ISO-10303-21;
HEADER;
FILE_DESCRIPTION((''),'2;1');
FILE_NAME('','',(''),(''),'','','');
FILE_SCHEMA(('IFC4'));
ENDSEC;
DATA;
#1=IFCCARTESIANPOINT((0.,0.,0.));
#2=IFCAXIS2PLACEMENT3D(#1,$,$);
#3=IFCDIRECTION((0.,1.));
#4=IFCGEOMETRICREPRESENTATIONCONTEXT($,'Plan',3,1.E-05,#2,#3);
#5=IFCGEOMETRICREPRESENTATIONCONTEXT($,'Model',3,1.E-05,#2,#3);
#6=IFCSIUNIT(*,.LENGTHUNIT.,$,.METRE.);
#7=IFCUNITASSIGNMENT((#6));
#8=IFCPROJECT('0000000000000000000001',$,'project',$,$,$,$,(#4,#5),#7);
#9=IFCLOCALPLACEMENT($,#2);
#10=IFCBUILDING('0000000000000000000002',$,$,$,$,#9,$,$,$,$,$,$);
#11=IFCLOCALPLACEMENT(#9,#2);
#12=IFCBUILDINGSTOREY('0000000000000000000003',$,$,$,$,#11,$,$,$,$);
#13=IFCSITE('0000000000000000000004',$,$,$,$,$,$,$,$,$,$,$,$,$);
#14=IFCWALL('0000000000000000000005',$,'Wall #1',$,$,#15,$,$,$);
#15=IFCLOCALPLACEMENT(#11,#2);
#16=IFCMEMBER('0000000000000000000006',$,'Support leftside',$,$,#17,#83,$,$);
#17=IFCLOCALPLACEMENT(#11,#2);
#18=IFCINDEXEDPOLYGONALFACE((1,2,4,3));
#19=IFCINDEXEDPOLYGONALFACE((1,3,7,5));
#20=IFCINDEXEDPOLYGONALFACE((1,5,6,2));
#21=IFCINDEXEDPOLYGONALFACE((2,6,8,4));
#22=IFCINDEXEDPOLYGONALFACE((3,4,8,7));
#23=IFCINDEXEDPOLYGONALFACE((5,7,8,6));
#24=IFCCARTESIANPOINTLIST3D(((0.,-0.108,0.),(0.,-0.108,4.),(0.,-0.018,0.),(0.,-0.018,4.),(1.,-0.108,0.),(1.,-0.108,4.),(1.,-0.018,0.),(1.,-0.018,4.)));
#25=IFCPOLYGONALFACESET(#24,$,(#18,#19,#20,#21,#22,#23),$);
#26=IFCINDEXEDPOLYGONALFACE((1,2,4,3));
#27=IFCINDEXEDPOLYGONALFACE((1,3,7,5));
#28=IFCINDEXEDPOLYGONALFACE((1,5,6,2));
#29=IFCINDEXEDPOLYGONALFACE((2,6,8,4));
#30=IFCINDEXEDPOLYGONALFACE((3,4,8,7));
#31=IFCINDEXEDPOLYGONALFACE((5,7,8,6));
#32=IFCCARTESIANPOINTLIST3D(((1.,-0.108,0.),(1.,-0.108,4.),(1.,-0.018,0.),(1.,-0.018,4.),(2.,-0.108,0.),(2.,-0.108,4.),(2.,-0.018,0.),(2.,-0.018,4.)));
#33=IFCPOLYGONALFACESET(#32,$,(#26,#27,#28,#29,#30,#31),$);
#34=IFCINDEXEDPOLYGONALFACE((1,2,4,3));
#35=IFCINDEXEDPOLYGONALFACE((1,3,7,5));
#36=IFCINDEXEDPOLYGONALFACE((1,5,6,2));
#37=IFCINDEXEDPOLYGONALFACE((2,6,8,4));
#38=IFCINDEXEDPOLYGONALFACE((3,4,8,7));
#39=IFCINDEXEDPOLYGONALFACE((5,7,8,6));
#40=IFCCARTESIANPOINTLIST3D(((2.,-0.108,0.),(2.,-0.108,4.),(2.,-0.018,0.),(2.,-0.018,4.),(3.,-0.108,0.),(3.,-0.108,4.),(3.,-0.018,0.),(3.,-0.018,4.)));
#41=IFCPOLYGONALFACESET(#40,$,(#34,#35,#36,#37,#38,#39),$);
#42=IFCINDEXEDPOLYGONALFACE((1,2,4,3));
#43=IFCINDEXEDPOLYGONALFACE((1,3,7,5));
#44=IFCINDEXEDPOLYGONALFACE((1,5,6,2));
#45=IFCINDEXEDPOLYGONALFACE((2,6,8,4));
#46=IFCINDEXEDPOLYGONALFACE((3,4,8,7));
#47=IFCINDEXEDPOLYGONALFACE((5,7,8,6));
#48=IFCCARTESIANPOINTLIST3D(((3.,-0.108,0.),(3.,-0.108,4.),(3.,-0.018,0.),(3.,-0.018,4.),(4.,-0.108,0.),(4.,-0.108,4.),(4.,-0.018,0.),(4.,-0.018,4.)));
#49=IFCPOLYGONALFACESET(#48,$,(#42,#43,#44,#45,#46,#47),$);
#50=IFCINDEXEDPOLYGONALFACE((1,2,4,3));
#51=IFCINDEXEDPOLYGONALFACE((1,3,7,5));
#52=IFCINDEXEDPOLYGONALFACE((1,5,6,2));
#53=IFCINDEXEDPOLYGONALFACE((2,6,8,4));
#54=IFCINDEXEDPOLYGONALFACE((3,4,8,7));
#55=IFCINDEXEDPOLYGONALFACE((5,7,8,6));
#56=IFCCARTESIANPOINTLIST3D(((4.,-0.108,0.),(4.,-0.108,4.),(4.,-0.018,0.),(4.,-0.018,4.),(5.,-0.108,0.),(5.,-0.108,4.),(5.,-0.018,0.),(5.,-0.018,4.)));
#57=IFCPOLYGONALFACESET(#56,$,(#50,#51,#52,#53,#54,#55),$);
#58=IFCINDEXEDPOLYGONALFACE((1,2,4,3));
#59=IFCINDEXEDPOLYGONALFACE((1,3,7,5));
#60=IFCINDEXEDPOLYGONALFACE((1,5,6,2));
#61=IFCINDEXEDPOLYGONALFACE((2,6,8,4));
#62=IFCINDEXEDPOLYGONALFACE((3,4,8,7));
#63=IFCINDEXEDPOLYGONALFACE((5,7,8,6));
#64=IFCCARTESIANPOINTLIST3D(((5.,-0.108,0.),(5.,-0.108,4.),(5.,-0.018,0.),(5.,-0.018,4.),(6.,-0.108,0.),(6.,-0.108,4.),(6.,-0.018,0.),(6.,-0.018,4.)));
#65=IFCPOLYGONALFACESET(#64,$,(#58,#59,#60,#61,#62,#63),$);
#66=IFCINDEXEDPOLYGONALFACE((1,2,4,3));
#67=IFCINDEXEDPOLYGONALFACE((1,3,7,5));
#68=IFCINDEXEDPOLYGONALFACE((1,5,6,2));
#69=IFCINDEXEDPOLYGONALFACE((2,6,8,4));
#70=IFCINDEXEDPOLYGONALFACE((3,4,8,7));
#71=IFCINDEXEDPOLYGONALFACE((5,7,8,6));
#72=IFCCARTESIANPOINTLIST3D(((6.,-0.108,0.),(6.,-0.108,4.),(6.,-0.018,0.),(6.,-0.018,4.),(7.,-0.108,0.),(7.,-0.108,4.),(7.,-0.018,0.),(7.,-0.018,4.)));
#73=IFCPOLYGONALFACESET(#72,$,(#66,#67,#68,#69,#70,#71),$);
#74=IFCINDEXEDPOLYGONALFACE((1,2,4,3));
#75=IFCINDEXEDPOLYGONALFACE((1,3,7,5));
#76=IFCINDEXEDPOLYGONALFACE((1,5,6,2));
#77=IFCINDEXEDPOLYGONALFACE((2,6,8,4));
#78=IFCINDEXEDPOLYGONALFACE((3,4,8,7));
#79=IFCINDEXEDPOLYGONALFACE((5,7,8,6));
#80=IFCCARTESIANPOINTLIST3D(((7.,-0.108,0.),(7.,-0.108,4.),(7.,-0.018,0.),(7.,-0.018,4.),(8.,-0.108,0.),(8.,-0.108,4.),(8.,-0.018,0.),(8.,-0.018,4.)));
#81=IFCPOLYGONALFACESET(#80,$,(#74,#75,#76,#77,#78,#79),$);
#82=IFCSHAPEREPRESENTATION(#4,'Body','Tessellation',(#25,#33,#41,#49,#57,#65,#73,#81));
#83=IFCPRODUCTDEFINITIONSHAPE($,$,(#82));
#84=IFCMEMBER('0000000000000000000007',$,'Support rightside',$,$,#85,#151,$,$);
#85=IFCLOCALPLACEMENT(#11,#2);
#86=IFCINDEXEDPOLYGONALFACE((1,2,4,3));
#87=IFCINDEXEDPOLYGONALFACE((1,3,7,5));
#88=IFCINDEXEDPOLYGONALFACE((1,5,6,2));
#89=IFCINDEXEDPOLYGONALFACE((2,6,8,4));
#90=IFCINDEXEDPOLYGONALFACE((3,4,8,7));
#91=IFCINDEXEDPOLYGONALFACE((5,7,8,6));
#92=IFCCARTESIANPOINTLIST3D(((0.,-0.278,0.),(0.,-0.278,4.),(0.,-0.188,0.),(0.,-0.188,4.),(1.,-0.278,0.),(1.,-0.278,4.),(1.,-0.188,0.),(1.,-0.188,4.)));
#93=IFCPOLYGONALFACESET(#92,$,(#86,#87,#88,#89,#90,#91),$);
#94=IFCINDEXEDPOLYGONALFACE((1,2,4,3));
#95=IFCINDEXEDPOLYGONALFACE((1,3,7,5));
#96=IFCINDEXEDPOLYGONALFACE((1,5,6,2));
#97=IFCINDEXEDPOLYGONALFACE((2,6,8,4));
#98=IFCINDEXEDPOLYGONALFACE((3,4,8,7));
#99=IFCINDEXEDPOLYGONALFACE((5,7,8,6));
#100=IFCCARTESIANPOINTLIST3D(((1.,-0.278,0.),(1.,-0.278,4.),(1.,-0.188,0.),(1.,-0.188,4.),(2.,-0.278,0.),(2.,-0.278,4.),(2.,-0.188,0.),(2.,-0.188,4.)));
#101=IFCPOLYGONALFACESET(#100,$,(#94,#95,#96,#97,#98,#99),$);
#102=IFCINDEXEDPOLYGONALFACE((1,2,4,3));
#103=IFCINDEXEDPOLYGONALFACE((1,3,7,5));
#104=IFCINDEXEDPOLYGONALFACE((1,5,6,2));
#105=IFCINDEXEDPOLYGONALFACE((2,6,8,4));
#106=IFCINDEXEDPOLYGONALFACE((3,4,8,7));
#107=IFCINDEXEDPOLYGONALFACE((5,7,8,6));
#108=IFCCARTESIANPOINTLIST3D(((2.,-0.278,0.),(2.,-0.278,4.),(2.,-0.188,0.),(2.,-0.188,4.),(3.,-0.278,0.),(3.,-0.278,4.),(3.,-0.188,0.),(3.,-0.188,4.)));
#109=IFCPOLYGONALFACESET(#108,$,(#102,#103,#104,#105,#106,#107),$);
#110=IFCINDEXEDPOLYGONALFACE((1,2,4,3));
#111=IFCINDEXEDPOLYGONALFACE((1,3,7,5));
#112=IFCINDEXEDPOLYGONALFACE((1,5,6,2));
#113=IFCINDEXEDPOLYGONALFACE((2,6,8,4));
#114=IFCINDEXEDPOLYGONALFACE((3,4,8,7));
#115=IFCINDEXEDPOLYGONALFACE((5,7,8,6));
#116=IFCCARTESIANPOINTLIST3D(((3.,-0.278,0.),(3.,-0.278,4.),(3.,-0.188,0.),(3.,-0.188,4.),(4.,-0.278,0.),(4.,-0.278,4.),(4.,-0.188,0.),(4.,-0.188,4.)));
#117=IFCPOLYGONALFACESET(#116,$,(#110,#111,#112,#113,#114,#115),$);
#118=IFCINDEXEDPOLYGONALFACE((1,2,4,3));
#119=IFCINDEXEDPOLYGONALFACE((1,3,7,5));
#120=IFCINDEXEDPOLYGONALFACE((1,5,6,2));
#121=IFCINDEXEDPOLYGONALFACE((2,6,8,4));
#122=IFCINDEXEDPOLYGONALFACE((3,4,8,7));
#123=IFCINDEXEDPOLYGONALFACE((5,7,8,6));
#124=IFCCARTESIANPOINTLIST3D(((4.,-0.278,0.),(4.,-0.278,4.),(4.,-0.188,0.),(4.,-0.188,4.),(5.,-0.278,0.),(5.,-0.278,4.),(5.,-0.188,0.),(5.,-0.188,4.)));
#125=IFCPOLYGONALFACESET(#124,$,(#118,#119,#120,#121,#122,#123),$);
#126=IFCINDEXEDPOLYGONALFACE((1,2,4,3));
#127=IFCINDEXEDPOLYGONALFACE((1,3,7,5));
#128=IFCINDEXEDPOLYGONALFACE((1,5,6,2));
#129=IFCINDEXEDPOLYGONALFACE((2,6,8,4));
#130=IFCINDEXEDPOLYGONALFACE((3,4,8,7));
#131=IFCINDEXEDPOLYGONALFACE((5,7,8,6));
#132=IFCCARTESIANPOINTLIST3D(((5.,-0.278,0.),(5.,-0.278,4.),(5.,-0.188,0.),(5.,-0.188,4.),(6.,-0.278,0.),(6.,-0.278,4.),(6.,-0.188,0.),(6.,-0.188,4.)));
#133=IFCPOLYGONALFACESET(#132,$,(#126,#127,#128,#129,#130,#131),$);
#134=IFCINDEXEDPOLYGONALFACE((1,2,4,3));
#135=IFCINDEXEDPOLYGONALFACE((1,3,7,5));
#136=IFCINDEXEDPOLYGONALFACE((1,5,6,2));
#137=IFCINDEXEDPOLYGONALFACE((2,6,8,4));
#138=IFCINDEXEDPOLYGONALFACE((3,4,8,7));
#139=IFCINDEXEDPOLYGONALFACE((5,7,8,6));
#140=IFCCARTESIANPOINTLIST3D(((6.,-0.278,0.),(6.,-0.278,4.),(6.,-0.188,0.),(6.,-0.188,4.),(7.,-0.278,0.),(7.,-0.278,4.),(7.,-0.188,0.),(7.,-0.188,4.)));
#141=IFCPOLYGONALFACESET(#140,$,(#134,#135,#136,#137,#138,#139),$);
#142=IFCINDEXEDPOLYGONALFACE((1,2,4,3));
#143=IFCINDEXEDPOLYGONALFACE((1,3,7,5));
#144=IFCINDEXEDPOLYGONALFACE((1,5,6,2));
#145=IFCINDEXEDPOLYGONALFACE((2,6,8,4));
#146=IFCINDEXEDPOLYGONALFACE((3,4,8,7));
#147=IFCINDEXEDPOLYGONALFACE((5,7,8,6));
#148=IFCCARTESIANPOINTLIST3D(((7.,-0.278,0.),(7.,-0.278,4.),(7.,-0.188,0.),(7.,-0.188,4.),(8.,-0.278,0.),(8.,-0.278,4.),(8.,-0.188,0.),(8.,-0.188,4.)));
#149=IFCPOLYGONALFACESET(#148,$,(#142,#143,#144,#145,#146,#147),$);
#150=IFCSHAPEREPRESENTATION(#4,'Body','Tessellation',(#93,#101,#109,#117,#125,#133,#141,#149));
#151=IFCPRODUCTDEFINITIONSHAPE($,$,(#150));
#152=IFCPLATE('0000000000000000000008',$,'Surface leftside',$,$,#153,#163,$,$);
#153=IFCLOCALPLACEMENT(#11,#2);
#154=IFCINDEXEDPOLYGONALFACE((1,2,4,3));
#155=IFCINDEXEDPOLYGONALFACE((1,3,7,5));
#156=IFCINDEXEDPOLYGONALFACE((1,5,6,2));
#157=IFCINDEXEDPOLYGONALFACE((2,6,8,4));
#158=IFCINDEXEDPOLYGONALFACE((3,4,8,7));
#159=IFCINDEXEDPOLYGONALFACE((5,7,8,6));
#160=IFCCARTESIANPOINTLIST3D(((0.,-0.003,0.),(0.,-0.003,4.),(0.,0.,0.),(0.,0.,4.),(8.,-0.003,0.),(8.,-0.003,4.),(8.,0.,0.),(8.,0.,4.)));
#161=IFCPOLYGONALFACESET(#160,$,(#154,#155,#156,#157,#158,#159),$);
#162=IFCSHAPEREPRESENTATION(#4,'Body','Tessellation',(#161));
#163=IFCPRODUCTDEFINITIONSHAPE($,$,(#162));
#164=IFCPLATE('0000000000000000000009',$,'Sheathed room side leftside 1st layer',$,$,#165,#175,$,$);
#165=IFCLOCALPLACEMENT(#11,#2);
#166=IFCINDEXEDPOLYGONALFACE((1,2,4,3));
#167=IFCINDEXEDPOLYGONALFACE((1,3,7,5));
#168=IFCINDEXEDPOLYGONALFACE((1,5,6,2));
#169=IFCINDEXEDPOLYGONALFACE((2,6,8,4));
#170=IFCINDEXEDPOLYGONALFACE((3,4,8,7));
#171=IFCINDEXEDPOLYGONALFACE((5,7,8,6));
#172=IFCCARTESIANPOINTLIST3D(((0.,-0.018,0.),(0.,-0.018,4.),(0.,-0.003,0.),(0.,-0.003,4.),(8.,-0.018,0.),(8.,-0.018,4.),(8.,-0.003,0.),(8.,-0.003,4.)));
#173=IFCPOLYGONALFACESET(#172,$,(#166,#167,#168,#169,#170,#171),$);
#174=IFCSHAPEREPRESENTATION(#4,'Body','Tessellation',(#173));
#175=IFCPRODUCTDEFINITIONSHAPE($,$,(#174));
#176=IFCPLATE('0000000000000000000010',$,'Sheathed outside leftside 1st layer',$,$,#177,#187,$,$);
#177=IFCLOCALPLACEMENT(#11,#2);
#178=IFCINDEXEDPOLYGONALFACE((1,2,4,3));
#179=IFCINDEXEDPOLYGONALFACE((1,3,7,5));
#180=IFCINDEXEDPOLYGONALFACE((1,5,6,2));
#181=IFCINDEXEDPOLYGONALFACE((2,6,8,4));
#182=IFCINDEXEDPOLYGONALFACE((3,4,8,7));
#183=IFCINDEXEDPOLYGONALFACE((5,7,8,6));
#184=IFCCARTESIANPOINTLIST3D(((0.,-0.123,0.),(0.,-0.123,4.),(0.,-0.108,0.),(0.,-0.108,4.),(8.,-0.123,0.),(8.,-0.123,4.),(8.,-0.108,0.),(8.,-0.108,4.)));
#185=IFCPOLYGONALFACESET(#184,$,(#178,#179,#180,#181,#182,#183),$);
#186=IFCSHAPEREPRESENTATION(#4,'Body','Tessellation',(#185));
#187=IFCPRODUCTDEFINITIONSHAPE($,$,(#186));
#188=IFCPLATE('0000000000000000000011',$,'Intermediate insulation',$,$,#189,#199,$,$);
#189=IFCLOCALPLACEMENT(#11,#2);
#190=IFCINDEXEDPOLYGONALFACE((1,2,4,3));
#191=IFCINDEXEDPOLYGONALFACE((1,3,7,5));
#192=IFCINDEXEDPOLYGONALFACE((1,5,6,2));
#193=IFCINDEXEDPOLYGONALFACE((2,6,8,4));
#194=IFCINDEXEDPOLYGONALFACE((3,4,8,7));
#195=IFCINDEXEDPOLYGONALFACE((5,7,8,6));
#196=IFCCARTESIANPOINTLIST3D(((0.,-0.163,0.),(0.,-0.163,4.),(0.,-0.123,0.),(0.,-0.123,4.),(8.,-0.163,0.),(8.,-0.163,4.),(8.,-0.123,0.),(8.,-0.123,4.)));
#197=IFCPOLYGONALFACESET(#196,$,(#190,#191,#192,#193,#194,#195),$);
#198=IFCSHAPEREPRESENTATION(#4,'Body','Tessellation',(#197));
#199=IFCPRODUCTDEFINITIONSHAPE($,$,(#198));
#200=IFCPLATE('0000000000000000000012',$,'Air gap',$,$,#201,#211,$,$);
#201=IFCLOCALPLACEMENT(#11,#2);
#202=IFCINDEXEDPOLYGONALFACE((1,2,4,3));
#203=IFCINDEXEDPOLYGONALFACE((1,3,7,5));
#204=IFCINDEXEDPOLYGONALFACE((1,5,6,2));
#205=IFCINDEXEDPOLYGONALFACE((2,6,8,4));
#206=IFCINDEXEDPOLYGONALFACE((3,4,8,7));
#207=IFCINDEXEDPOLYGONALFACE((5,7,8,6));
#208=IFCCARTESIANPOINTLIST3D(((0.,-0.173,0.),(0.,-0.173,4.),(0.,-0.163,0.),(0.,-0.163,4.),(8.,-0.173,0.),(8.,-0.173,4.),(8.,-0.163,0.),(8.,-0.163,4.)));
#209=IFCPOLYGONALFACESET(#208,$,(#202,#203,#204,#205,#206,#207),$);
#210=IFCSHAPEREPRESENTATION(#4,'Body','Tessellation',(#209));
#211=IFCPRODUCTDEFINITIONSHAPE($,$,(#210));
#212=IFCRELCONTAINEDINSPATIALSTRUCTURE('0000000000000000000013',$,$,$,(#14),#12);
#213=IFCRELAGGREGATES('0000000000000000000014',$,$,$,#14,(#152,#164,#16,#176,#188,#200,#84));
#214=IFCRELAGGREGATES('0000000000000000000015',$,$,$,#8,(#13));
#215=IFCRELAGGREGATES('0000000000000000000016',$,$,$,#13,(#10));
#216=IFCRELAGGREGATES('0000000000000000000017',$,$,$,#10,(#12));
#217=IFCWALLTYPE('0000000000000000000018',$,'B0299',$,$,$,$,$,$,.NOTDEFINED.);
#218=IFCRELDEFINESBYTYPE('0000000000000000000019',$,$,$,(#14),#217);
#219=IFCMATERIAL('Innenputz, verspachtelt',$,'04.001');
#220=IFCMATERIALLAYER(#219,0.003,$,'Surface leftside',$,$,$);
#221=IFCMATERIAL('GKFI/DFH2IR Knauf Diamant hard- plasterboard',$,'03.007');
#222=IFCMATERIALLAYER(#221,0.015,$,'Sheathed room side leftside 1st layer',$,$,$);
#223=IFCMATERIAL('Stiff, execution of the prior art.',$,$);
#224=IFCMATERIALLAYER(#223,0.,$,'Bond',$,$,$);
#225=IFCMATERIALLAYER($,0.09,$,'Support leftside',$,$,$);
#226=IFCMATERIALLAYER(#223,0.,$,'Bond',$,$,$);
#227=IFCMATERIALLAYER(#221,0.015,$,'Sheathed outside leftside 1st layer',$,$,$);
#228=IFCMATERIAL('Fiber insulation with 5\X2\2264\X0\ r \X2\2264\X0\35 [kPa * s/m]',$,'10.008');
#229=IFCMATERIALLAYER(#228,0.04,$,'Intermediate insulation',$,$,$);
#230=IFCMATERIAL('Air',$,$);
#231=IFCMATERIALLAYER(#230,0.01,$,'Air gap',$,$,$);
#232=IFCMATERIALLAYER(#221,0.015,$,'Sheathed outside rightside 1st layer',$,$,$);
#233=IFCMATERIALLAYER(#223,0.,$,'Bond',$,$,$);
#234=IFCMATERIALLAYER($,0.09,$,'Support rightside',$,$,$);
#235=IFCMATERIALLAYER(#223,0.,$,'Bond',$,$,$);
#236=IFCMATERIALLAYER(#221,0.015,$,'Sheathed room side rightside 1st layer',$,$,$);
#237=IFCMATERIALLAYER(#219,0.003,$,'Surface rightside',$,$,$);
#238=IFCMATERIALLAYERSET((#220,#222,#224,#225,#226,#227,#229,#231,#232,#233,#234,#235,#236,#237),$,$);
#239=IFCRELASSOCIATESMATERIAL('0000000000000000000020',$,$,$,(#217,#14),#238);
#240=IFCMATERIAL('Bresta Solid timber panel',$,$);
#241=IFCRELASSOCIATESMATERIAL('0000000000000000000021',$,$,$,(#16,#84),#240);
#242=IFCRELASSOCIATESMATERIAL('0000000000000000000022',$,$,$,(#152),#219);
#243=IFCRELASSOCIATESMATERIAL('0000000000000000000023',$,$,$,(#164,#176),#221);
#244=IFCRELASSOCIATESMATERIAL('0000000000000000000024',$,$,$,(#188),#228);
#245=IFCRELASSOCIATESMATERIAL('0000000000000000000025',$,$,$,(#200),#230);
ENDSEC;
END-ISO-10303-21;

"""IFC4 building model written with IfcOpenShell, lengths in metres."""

from ifc_helpers import new_model, si_unit, direction, frame, frame_2d, origin, origin_with_axes, place, context, project, spatial, rectangle, extrude, material, layer, layer_set, type_object, element, aggregate, save


model = new_model("IFC4")

# Units and contexts
plan_context = context("Plan", 3, precision=1e-05, world=origin(), true_north=direction((0.0, 1.0)))
model_context = context("Model", 3, precision=1e-05, world=origin(), true_north=direction((0.0, 1.0)))
ifc_project = project(units=[si_unit("LENGTHUNIT", "METRE")], contexts=[plan_context, model_context])

# Site, building, storey
site = spatial("IfcSite", under=ifc_project)
building_placement = place(None, origin())
building = spatial("IfcBuilding", under=site, at=building_placement)
storey_placement = place(building_placement, origin())
storey = spatial("IfcBuildingStorey", under=building, at=storey_placement)

# Wall, members, plates
ifc_material_1 = material(Name="Innenputz, verspachtelt", Category="04.001")
ifc_layer_1 = layer(ifc_material_1, 0.003, Name="Surface leftside")
ifc_material_2 = material(Name="GKFI/DFH2IR Knauf Diamant hard- plasterboard", Category="03.007")
ifc_layer_2 = layer(ifc_material_2, 0.015, Name="Sheathed room side leftside 1st layer")
ifc_material_3 = material(Name="Stiff, execution of the prior art.")
ifc_layer_3 = layer(ifc_material_3, 0.0, Name="Bond")
ifc_layer_4 = layer(None, 0.09, Name="Support leftside")
ifc_layer_5 = layer(ifc_material_3, 0.0, Name="Bond")
ifc_layer_6 = layer(ifc_material_2, 0.015, Name="Sheathed outside leftside 1st layer")
ifc_material_4 = material(Name="Fiber insulation with 5≤ r ≤35 [kPa * s/m]", Category="10.008")
ifc_layer_7 = layer(ifc_material_4, 0.04, Name="Intermediate insulation")
ifc_material_5 = material(Name="Air")
ifc_layer_8 = layer(ifc_material_5, 0.01, Name="Air gap")
ifc_layer_9 = layer(ifc_material_2, 0.015, Name="Sheathed outside rightside 1st layer")
ifc_layer_10 = layer(ifc_material_3, 0.0, Name="Bond")
ifc_layer_11 = layer(None, 0.09, Name="Support rightside")
ifc_layer_12 = layer(ifc_material_3, 0.0, Name="Bond")
ifc_layer_13 = layer(ifc_material_2, 0.015, Name="Sheathed room side rightside 1st layer")
ifc_layer_14 = layer(ifc_material_1, 0.003, Name="Surface rightside")
ifc_layer_set = layer_set([ifc_layer_1, ifc_layer_2, ifc_layer_3, ifc_layer_4, ifc_layer_5, ifc_layer_6, ifc_layer_7, ifc_layer_8, ifc_layer_9, ifc_layer_10, ifc_layer_11, ifc_layer_12, ifc_layer_13, ifc_layer_14])
wall_type = type_object("IfcWallType", Name="B0299", PredefinedType="NOTDEFINED", material=ifc_layer_set)
wall_placement = place(None, frame((0.0, 0.0, 0.0), z_axis=(0.0, -1.0, 0.0), x_axis=(1.0, 0.0, 0.0)))
wall = element("IfcWall", 1, at=wall_placement, inside=storey, type_object=wall_type, material=ifc_layer_set, Name="Wall #1")
ifc_material_6 = material(Name="Bresta Solid timber panel")
member_1_placement = place(wall_placement, origin())
member_1 = element("IfcMember", 2, at=member_1_placement, material=ifc_material_6, Name="Support leftside", context=plan_context, shape_type="SweptSolid", body=[
    extrude(rectangle(XDim=1.0, YDim=0.09, at=frame_2d((0.5, 0.045), x_axis=(1.0, 0.0))), frame((0.0, 4.0, 0.018), z_axis=(0.0, -1.0, 0.0), x_axis=(1.0, 0.0, 0.0)), (0.0, 0.0, 1.0), 4.0),
    extrude(rectangle(XDim=1.0, YDim=0.09, at=frame_2d((0.5, 0.045), x_axis=(1.0, 0.0))), frame((1.0, 4.0, 0.018), z_axis=(0.0, -1.0, 0.0), x_axis=(1.0, 0.0, 0.0)), (0.0, 0.0, 1.0), 4.0),
    extrude(rectangle(XDim=1.0, YDim=0.09, at=frame_2d((0.5, 0.045), x_axis=(1.0, 0.0))), frame((2.0, 4.0, 0.018), z_axis=(0.0, -1.0, 0.0), x_axis=(1.0, 0.0, 0.0)), (0.0, 0.0, 1.0), 4.0),
    extrude(rectangle(XDim=1.0, YDim=0.09, at=frame_2d((0.5, 0.045), x_axis=(1.0, 0.0))), frame((3.0, 4.0, 0.018), z_axis=(0.0, -1.0, 0.0), x_axis=(1.0, 0.0, 0.0)), (0.0, 0.0, 1.0), 4.0),
    extrude(rectangle(XDim=1.0, YDim=0.09, at=frame_2d((0.5, 0.045), x_axis=(1.0, 0.0))), frame((4.0, 4.0, 0.018), z_axis=(0.0, -1.0, 0.0), x_axis=(1.0, 0.0, 0.0)), (0.0, 0.0, 1.0), 4.0),
    extrude(rectangle(XDim=1.0, YDim=0.09, at=frame_2d((0.5, 0.045), x_axis=(1.0, 0.0))), frame((5.0, 4.0, 0.018), z_axis=(0.0, -1.0, 0.0), x_axis=(1.0, 0.0, 0.0)), (0.0, 0.0, 1.0), 4.0),
    extrude(rectangle(XDim=1.0, YDim=0.09, at=frame_2d((0.5, 0.045), x_axis=(1.0, 0.0))), frame((6.0, 4.0, 0.018), z_axis=(0.0, -1.0, 0.0), x_axis=(1.0, 0.0, 0.0)), (0.0, 0.0, 1.0), 4.0),
    extrude(rectangle(XDim=1.0, YDim=0.09, at=frame_2d((0.5, 0.045), x_axis=(1.0, 0.0))), frame((7.0, 4.0, 0.018), z_axis=(0.0, -1.0, 0.0), x_axis=(1.0, 0.0, 0.0)), (0.0, 0.0, 1.0), 4.0),
])
member_2_placement = place(wall_placement, origin())
member_2 = element("IfcMember", 3, at=member_2_placement, material=ifc_material_6, Name="Support rightside", context=plan_context, shape_type="SweptSolid", body=[
    extrude(rectangle(XDim=1.0, YDim=0.09, at=frame_2d((0.5, 0.045), x_axis=(1.0, 0.0))), frame((0.0, 4.0, 0.188), z_axis=(0.0, -1.0, 0.0), x_axis=(1.0, 0.0, 0.0)), (0.0, 0.0, 1.0), 4.0),
    extrude(rectangle(XDim=1.0, YDim=0.09, at=frame_2d((0.5, 0.045), x_axis=(1.0, 0.0))), frame((1.0, 4.0, 0.188), z_axis=(0.0, -1.0, 0.0), x_axis=(1.0, 0.0, 0.0)), (0.0, 0.0, 1.0), 4.0),
    extrude(rectangle(XDim=1.0, YDim=0.09, at=frame_2d((0.5, 0.045), x_axis=(1.0, 0.0))), frame((2.0, 4.0, 0.188), z_axis=(0.0, -1.0, 0.0), x_axis=(1.0, 0.0, 0.0)), (0.0, 0.0, 1.0), 4.0),
    extrude(rectangle(XDim=1.0, YDim=0.09, at=frame_2d((0.5, 0.045), x_axis=(1.0, 0.0))), frame((3.0, 4.0, 0.188), z_axis=(0.0, -1.0, 0.0), x_axis=(1.0, 0.0, 0.0)), (0.0, 0.0, 1.0), 4.0),
    extrude(rectangle(XDim=1.0, YDim=0.09, at=frame_2d((0.5, 0.045), x_axis=(1.0, 0.0))), frame((4.0, 4.0, 0.188), z_axis=(0.0, -1.0, 0.0), x_axis=(1.0, 0.0, 0.0)), (0.0, 0.0, 1.0), 4.0),
    extrude(rectangle(XDim=1.0, YDim=0.09, at=frame_2d((0.5, 0.045), x_axis=(1.0, 0.0))), frame((5.0, 4.0, 0.188), z_axis=(0.0, -1.0, 0.0), x_axis=(1.0, 0.0, 0.0)), (0.0, 0.0, 1.0), 4.0),
    extrude(rectangle(XDim=1.0, YDim=0.09, at=frame_2d((0.5, 0.045), x_axis=(1.0, 0.0))), frame((6.0, 4.0, 0.188), z_axis=(0.0, -1.0, 0.0), x_axis=(1.0, 0.0, 0.0)), (0.0, 0.0, 1.0), 4.0),
    extrude(rectangle(XDim=1.0, YDim=0.09, at=frame_2d((0.5, 0.045), x_axis=(1.0, 0.0))), frame((7.0, 4.0, 0.188), z_axis=(0.0, -1.0, 0.0), x_axis=(1.0, 0.0, 0.0)), (0.0, 0.0, 1.0), 4.0),
])
plate_1_placement = place(wall_placement, origin())
plate_1 = element("IfcPlate", 4, at=plate_1_placement, material=ifc_material_1, Name="Surface leftside", context=plan_context, shape_type="SweptSolid", body=[
    extrude(rectangle(XDim=8.0, YDim=4.0, at=frame_2d((4.0, 2.0), x_axis=(1.0, 0.0))), origin_with_axes(), (0.0, 0.0, 1.0), 0.003),
])
plate_2_placement = place(wall_placement, origin())
plate_2 = element("IfcPlate", 5, at=plate_2_placement, material=ifc_material_2, Name="Sheathed room side leftside 1st layer", context=plan_context, shape_type="SweptSolid", body=[
    extrude(rectangle(XDim=8.0, YDim=4.0, at=frame_2d((4.0, 2.0), x_axis=(1.0, 0.0))), frame((0.0, 0.0, 0.003), z_axis=(0.0, 0.0, 1.0), x_axis=(1.0, 0.0, 0.0)), (0.0, 0.0, 1.0), 0.015),
])
plate_3_placement = place(wall_placement, origin())
plate_3 = element("IfcPlate", 6, at=plate_3_placement, material=ifc_material_2, Name="Sheathed outside leftside 1st layer", context=plan_context, shape_type="SweptSolid", body=[
    extrude(rectangle(XDim=8.0, YDim=4.0, at=frame_2d((4.0, 2.0), x_axis=(1.0, 0.0))), frame((0.0, 0.0, 0.108), z_axis=(0.0, 0.0, 1.0), x_axis=(1.0, 0.0, 0.0)), (0.0, 0.0, 1.0), 0.015),
])
plate_4_placement = place(wall_placement, origin())
plate_4 = element("IfcPlate", 7, at=plate_4_placement, material=ifc_material_4, Name="Intermediate insulation", context=plan_context, shape_type="SweptSolid", body=[
    extrude(rectangle(XDim=8.0, YDim=4.0, at=frame_2d((4.0, 2.0), x_axis=(1.0, 0.0))), frame((0.0, 0.0, 0.123), z_axis=(0.0, 0.0, 1.0), x_axis=(1.0, 0.0, 0.0)), (0.0, 0.0, 1.0), 0.04),
])
plate_5_placement = place(wall_placement, origin())
plate_5 = element("IfcPlate", 8, at=plate_5_placement, material=ifc_material_5, Name="Air gap", context=plan_context, shape_type="SweptSolid", body=[
    extrude(rectangle(XDim=8.0, YDim=4.0, at=frame_2d((4.0, 2.0), x_axis=(1.0, 0.0))), frame((0.0, 0.0, 0.163), z_axis=(0.0, 0.0, 1.0), x_axis=(1.0, 0.0, 0.0)), (0.0, 0.0, 1.0), 0.01),
])
aggregate(wall, [plate_1, plate_2, member_1, plate_3, plate_4, plate_5, member_2])

save(model, "model.ifc")
